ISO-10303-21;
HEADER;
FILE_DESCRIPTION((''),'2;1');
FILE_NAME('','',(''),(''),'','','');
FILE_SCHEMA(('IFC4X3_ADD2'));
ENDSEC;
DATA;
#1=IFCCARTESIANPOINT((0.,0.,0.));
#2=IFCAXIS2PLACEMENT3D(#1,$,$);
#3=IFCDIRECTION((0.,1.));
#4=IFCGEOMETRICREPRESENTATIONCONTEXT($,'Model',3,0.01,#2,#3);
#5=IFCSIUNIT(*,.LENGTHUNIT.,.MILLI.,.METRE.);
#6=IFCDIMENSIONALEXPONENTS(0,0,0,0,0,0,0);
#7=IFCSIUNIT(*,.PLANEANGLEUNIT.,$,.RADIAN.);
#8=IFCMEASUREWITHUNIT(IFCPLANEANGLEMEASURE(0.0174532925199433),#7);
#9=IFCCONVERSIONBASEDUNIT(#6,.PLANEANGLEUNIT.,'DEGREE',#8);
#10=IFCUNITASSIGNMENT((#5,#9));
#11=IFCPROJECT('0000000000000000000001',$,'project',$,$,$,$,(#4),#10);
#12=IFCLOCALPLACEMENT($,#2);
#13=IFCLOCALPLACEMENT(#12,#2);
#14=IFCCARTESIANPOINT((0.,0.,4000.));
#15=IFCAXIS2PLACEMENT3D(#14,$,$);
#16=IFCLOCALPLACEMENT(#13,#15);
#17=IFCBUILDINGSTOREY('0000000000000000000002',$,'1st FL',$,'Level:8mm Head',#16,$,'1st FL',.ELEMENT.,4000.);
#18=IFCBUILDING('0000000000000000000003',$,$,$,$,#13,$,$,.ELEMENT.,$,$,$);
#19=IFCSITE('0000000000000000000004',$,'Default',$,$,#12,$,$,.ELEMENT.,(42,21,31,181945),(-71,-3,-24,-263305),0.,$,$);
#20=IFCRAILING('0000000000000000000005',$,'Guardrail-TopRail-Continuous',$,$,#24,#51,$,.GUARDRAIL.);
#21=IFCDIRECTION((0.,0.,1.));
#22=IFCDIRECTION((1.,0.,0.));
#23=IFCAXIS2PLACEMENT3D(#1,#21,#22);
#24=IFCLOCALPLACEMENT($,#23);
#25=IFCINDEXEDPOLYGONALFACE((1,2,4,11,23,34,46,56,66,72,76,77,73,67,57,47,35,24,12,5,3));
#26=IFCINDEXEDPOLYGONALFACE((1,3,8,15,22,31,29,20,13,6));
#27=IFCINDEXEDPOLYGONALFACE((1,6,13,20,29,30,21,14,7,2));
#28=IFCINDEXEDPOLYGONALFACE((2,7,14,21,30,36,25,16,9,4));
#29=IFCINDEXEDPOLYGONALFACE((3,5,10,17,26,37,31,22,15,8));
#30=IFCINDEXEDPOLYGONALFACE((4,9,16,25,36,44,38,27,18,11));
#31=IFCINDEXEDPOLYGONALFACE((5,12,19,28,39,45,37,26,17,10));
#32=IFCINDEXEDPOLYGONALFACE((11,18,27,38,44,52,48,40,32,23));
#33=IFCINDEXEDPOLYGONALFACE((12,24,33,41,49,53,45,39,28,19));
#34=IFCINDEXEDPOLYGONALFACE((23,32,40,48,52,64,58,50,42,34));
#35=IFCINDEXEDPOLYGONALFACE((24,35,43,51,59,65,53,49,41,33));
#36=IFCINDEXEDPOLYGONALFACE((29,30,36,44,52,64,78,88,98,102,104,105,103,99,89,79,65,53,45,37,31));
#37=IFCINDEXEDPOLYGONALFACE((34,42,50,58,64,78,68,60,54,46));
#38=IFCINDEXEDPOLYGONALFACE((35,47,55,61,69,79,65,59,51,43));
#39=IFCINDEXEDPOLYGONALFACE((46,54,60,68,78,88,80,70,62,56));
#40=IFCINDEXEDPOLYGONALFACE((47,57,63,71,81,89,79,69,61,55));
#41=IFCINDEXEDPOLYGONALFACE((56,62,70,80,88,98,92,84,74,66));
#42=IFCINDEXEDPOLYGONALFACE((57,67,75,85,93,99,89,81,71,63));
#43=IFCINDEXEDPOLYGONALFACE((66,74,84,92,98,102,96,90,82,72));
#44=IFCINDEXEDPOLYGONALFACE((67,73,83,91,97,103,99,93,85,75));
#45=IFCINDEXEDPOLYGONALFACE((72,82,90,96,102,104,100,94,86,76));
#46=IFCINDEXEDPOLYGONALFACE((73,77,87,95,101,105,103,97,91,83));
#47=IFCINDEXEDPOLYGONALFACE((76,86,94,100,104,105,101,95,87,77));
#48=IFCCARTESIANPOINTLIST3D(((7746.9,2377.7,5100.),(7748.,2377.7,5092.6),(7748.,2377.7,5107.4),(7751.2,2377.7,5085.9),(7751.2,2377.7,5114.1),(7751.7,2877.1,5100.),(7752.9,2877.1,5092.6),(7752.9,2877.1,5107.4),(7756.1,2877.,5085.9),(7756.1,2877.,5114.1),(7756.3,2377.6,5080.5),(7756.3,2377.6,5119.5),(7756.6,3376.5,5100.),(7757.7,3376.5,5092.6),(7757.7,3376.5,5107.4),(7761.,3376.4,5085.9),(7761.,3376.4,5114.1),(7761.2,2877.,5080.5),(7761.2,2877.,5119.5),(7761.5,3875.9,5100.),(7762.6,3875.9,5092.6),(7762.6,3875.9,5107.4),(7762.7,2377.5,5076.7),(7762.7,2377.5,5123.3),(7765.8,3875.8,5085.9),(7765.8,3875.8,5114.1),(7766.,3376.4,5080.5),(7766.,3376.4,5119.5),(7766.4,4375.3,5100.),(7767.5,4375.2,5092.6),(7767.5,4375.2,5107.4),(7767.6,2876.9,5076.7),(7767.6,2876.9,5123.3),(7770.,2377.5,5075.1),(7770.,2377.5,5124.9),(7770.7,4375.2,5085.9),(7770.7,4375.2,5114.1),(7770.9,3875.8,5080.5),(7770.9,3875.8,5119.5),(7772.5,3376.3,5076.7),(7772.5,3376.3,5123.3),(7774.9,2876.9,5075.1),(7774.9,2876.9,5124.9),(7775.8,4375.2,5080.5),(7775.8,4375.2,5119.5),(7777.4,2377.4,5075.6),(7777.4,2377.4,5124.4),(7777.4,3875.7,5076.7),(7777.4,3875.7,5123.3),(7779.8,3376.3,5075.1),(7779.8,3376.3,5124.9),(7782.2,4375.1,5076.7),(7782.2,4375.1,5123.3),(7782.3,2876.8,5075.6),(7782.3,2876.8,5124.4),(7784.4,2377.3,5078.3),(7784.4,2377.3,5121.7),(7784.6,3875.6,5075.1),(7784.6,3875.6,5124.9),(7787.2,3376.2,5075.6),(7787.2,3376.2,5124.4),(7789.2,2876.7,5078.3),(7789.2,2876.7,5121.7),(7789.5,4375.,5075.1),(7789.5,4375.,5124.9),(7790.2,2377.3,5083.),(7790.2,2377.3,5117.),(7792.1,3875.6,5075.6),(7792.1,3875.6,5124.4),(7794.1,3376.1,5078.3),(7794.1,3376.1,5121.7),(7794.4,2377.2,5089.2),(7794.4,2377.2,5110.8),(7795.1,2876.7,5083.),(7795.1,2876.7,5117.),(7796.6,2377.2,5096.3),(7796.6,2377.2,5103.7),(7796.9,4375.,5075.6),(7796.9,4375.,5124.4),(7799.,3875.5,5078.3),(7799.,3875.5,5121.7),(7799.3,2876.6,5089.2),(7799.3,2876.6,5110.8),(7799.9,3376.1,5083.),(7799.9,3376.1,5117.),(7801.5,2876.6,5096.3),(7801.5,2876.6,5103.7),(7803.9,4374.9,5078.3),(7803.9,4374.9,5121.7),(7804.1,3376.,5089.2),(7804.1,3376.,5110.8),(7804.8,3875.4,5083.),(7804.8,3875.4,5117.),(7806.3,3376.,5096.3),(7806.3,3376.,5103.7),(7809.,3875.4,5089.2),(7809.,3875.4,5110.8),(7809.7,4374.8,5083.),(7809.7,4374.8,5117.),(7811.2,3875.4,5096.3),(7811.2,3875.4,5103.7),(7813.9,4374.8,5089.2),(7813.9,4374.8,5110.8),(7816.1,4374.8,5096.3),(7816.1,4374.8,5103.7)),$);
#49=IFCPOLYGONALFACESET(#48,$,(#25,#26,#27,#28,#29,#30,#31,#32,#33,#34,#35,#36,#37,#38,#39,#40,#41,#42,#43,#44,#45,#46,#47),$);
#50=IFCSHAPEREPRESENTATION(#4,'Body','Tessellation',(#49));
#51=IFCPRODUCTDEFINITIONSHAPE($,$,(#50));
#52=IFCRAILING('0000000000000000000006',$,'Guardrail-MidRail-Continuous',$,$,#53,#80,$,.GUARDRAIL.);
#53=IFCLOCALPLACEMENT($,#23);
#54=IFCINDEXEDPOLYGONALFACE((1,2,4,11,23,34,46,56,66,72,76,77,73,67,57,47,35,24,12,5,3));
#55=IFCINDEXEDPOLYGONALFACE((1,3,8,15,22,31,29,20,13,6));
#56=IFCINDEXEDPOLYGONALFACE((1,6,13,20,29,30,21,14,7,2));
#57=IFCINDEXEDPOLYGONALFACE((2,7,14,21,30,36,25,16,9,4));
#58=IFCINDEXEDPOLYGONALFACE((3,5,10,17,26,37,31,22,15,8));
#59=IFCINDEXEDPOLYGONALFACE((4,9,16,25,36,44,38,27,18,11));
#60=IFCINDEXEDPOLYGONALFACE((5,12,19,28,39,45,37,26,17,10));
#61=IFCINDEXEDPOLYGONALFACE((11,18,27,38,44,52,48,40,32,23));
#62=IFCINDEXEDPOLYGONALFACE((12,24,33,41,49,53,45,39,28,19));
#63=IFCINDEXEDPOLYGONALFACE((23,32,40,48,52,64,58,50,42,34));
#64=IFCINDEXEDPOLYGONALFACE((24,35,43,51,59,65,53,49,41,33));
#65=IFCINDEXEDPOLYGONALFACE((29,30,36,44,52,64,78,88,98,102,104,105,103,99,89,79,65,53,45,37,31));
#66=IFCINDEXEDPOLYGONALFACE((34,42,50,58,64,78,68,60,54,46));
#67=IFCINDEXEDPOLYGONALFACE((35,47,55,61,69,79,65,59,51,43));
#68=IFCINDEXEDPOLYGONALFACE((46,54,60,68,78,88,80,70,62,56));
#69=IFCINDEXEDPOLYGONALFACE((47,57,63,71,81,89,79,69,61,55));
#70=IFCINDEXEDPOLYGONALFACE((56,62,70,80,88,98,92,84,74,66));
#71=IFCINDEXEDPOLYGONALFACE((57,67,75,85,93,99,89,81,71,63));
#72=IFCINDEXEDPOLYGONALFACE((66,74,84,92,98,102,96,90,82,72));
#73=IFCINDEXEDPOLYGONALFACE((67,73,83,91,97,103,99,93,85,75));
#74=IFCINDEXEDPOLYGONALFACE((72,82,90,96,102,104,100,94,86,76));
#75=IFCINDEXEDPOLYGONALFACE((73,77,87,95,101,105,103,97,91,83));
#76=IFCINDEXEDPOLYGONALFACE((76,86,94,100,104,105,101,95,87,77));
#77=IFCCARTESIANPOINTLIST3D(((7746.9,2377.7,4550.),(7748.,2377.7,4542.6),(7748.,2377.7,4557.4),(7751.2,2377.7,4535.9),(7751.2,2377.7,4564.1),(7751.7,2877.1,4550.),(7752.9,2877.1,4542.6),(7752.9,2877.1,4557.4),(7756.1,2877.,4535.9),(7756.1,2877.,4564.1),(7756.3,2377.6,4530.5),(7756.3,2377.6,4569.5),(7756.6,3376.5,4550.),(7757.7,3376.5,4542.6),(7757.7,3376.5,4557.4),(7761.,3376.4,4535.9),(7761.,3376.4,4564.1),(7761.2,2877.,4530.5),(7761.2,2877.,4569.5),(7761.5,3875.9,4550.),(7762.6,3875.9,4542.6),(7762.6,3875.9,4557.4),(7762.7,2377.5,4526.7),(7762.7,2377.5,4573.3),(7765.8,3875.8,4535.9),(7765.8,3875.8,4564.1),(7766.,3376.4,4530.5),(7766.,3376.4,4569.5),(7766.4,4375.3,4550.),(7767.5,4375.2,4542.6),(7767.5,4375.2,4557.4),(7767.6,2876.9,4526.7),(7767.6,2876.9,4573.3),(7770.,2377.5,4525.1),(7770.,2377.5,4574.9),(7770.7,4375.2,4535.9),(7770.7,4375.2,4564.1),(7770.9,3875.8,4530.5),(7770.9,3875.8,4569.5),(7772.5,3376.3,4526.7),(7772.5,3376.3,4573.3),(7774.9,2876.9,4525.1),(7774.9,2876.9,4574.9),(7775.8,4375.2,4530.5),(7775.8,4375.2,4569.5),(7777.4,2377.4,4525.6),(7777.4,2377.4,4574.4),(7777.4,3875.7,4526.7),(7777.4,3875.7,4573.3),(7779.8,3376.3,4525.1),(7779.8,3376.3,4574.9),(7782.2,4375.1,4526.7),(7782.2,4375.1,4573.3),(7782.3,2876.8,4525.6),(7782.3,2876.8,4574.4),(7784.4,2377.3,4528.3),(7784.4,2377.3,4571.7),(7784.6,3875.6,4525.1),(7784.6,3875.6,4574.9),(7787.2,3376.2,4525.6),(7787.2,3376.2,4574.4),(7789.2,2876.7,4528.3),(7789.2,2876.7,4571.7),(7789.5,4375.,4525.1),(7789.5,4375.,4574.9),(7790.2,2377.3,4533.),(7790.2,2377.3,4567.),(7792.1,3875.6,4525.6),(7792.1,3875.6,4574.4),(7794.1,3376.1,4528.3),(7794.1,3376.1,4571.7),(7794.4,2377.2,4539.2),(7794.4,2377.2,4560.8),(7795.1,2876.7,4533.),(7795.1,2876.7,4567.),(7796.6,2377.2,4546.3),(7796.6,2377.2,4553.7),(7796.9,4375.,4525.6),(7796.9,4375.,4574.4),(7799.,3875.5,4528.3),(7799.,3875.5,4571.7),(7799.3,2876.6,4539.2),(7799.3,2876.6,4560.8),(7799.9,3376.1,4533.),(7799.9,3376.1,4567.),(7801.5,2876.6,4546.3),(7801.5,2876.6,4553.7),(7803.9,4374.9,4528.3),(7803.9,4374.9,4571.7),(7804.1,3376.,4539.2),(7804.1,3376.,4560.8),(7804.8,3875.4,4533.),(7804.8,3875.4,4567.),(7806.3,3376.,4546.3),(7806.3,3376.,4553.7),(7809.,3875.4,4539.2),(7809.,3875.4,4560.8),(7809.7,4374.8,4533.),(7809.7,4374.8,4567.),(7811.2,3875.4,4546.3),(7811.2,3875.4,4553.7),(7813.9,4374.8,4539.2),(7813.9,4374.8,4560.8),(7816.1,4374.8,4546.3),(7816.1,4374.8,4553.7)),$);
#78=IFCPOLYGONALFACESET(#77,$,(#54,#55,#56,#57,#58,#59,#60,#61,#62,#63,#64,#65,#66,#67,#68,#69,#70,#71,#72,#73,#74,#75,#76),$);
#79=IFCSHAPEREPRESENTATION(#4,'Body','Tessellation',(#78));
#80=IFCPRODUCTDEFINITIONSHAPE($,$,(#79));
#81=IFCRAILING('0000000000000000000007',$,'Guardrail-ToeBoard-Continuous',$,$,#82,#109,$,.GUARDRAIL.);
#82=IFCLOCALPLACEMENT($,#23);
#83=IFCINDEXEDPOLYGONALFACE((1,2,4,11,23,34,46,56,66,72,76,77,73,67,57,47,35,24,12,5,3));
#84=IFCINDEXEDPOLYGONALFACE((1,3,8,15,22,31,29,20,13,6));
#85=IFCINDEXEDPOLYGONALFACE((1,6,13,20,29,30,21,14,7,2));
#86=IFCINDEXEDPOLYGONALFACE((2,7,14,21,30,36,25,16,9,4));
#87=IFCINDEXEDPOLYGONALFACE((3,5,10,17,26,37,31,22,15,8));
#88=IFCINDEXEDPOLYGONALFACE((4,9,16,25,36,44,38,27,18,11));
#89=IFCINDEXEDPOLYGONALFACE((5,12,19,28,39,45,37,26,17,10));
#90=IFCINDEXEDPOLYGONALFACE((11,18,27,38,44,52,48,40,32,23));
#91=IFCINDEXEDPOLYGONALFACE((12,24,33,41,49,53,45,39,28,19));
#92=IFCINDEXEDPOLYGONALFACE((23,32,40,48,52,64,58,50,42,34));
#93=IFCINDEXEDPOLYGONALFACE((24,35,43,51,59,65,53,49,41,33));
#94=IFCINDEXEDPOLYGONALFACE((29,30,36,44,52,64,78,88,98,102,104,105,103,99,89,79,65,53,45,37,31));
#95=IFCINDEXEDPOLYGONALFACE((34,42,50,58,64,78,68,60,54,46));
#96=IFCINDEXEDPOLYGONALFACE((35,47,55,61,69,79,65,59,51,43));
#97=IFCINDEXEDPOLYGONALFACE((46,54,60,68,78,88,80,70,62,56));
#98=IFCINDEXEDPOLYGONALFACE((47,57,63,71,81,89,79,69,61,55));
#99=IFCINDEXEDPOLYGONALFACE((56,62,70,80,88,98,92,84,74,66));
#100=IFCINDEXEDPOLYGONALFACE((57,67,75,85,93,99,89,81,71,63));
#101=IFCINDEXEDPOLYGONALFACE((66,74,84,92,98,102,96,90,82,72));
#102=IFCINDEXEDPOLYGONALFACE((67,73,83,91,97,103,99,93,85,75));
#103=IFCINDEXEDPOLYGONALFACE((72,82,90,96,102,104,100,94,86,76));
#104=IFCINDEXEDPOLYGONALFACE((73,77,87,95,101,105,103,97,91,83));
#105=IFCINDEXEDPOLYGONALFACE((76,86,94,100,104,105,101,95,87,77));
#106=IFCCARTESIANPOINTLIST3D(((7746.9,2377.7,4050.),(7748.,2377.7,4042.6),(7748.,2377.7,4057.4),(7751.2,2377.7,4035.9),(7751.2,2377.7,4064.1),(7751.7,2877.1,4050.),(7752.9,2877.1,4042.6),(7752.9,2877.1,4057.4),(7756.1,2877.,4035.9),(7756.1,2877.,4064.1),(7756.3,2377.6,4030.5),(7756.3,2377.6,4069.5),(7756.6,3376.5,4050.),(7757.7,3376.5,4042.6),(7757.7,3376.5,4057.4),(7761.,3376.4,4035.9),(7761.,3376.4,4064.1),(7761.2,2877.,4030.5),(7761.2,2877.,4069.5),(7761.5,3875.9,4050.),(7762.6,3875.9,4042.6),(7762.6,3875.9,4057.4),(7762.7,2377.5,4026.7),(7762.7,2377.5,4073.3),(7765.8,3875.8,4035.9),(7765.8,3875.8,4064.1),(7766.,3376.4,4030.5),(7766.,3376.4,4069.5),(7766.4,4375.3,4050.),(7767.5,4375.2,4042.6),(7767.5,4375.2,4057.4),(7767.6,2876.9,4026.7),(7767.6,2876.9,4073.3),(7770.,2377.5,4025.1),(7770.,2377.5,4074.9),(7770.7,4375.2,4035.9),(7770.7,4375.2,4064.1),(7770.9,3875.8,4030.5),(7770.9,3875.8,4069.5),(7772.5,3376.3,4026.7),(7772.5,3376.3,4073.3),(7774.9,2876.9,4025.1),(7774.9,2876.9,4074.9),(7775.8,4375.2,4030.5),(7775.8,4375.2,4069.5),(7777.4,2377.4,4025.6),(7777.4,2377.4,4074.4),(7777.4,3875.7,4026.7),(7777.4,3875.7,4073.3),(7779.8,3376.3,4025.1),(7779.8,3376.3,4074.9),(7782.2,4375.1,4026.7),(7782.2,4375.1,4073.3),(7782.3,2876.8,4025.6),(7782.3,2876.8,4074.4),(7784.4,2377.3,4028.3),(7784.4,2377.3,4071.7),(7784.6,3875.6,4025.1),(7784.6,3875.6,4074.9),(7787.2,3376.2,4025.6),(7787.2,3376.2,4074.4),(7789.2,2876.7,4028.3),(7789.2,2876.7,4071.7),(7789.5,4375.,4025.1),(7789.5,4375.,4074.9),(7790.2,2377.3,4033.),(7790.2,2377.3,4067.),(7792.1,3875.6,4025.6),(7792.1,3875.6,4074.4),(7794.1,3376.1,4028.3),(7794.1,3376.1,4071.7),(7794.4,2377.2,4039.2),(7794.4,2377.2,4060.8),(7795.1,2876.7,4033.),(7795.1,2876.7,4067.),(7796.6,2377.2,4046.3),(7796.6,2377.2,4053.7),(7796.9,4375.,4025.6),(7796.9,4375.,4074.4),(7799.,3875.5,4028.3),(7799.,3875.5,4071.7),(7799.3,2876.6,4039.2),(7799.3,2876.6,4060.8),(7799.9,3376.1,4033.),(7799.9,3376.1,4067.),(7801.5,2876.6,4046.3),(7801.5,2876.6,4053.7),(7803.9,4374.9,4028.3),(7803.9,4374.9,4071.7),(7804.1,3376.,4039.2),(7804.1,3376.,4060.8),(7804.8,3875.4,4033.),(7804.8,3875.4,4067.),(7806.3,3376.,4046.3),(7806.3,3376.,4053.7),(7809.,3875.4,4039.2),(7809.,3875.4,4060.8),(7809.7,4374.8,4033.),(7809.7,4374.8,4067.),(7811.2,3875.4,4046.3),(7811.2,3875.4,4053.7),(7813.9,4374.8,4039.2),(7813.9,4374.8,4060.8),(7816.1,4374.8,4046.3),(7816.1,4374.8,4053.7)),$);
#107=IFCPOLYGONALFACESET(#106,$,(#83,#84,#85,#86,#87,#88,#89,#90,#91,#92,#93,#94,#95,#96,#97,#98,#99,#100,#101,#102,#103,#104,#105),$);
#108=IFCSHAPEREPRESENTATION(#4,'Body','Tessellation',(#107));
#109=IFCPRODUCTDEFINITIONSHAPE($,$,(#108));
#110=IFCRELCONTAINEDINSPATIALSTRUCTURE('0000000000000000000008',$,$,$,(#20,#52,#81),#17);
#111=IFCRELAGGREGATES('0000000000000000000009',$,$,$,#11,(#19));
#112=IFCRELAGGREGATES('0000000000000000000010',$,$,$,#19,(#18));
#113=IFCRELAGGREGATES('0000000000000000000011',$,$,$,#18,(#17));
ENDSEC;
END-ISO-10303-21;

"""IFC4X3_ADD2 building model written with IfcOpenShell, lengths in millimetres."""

from ifc_helpers import new_model, entity, si_unit, converted_unit, direction, frame, origin, origin_with_axes, place, context, project, spatial, element, save


model = new_model("IFC4X3_ADD2")

# Units and contexts
model_context = context("Model", 3, precision=0.01, world=origin(), true_north=direction((0.0, 1.0)))
ifc_project = project(units=[si_unit("LENGTHUNIT", "METRE", prefix="MILLI"), converted_unit("PLANEANGLEUNIT", "DEGREE", entity("IfcPlaneAngleMeasure", 0.0174532925199433), si_unit("PLANEANGLEUNIT", "RADIAN"), dimensions=[0, 0, 0, 0, 0, 0, 0])], contexts=[model_context])

# Site, building, storey
site_placement = place(None, origin())
site = spatial("IfcSite", under=ifc_project, at=site_placement, Name="Default", CompositionType="ELEMENT", RefLatitude=(42, 21, 31, 181945), RefLongitude=(-71, -3, -24, -263305), RefElevation=0.0)
building_placement = place(site_placement, origin())
building = spatial("IfcBuilding", under=site, at=building_placement, CompositionType="ELEMENT")
storey_placement = place(building_placement, frame((0.0, 0.0, 4000.0)))
storey = spatial("IfcBuildingStorey", under=building, at=storey_placement, Name="1st FL", ObjectType="Level:8mm Head", LongName="1st FL", CompositionType="ELEMENT", Elevation=4000.0)

# Railings
railing_1_placement = place(None, origin_with_axes())
element("IfcRailing", 1, at=railing_1_placement, inside=storey, Name="Guardrail-TopRail-Continuous", PredefinedType="GUARDRAIL", context=model_context, shape_type="SweptSolid", body=[
    entity("IfcSweptDiskSolid", entity("IfcPolyline", [entity("IfcCartesianPoint", [7791.4, 4375.0, 5100.0]), entity("IfcCartesianPoint", [7786.5, 3875.6, 5100.0]), entity("IfcCartesianPoint", [7781.6, 3376.2, 5100.0]), entity("IfcCartesianPoint", [7776.7, 2876.8, 5100.0]), entity("IfcCartesianPoint", [7771.9, 2377.5, 5100.0])]), 25.0),
])
railing_2_placement = place(None, origin_with_axes())
element("IfcRailing", 2, at=railing_2_placement, inside=storey, Name="Guardrail-MidRail-Continuous", PredefinedType="GUARDRAIL", context=model_context, shape_type="SweptSolid", body=[
    entity("IfcSweptDiskSolid", entity("IfcPolyline", [entity("IfcCartesianPoint", [7791.4, 4375.0, 4550.0]), entity("IfcCartesianPoint", [7786.5, 3875.6, 4550.0]), entity("IfcCartesianPoint", [7781.6, 3376.2, 4550.0]), entity("IfcCartesianPoint", [7776.7, 2876.8, 4550.0]), entity("IfcCartesianPoint", [7771.9, 2377.5, 4550.0])]), 25.0),
])
railing_3_placement = place(None, origin_with_axes())
element("IfcRailing", 3, at=railing_3_placement, inside=storey, Name="Guardrail-ToeBoard-Continuous", PredefinedType="GUARDRAIL", context=model_context, shape_type="SweptSolid", body=[
    entity("IfcSweptDiskSolid", entity("IfcPolyline", [entity("IfcCartesianPoint", [7791.4, 4375.0, 4050.0]), entity("IfcCartesianPoint", [7786.5, 3875.6, 4050.0]), entity("IfcCartesianPoint", [7781.6, 3376.2, 4050.0]), entity("IfcCartesianPoint", [7776.7, 2876.8, 4050.0]), entity("IfcCartesianPoint", [7771.9, 2377.5, 4050.0])]), 25.0),
])

save(model, "model.ifc")
